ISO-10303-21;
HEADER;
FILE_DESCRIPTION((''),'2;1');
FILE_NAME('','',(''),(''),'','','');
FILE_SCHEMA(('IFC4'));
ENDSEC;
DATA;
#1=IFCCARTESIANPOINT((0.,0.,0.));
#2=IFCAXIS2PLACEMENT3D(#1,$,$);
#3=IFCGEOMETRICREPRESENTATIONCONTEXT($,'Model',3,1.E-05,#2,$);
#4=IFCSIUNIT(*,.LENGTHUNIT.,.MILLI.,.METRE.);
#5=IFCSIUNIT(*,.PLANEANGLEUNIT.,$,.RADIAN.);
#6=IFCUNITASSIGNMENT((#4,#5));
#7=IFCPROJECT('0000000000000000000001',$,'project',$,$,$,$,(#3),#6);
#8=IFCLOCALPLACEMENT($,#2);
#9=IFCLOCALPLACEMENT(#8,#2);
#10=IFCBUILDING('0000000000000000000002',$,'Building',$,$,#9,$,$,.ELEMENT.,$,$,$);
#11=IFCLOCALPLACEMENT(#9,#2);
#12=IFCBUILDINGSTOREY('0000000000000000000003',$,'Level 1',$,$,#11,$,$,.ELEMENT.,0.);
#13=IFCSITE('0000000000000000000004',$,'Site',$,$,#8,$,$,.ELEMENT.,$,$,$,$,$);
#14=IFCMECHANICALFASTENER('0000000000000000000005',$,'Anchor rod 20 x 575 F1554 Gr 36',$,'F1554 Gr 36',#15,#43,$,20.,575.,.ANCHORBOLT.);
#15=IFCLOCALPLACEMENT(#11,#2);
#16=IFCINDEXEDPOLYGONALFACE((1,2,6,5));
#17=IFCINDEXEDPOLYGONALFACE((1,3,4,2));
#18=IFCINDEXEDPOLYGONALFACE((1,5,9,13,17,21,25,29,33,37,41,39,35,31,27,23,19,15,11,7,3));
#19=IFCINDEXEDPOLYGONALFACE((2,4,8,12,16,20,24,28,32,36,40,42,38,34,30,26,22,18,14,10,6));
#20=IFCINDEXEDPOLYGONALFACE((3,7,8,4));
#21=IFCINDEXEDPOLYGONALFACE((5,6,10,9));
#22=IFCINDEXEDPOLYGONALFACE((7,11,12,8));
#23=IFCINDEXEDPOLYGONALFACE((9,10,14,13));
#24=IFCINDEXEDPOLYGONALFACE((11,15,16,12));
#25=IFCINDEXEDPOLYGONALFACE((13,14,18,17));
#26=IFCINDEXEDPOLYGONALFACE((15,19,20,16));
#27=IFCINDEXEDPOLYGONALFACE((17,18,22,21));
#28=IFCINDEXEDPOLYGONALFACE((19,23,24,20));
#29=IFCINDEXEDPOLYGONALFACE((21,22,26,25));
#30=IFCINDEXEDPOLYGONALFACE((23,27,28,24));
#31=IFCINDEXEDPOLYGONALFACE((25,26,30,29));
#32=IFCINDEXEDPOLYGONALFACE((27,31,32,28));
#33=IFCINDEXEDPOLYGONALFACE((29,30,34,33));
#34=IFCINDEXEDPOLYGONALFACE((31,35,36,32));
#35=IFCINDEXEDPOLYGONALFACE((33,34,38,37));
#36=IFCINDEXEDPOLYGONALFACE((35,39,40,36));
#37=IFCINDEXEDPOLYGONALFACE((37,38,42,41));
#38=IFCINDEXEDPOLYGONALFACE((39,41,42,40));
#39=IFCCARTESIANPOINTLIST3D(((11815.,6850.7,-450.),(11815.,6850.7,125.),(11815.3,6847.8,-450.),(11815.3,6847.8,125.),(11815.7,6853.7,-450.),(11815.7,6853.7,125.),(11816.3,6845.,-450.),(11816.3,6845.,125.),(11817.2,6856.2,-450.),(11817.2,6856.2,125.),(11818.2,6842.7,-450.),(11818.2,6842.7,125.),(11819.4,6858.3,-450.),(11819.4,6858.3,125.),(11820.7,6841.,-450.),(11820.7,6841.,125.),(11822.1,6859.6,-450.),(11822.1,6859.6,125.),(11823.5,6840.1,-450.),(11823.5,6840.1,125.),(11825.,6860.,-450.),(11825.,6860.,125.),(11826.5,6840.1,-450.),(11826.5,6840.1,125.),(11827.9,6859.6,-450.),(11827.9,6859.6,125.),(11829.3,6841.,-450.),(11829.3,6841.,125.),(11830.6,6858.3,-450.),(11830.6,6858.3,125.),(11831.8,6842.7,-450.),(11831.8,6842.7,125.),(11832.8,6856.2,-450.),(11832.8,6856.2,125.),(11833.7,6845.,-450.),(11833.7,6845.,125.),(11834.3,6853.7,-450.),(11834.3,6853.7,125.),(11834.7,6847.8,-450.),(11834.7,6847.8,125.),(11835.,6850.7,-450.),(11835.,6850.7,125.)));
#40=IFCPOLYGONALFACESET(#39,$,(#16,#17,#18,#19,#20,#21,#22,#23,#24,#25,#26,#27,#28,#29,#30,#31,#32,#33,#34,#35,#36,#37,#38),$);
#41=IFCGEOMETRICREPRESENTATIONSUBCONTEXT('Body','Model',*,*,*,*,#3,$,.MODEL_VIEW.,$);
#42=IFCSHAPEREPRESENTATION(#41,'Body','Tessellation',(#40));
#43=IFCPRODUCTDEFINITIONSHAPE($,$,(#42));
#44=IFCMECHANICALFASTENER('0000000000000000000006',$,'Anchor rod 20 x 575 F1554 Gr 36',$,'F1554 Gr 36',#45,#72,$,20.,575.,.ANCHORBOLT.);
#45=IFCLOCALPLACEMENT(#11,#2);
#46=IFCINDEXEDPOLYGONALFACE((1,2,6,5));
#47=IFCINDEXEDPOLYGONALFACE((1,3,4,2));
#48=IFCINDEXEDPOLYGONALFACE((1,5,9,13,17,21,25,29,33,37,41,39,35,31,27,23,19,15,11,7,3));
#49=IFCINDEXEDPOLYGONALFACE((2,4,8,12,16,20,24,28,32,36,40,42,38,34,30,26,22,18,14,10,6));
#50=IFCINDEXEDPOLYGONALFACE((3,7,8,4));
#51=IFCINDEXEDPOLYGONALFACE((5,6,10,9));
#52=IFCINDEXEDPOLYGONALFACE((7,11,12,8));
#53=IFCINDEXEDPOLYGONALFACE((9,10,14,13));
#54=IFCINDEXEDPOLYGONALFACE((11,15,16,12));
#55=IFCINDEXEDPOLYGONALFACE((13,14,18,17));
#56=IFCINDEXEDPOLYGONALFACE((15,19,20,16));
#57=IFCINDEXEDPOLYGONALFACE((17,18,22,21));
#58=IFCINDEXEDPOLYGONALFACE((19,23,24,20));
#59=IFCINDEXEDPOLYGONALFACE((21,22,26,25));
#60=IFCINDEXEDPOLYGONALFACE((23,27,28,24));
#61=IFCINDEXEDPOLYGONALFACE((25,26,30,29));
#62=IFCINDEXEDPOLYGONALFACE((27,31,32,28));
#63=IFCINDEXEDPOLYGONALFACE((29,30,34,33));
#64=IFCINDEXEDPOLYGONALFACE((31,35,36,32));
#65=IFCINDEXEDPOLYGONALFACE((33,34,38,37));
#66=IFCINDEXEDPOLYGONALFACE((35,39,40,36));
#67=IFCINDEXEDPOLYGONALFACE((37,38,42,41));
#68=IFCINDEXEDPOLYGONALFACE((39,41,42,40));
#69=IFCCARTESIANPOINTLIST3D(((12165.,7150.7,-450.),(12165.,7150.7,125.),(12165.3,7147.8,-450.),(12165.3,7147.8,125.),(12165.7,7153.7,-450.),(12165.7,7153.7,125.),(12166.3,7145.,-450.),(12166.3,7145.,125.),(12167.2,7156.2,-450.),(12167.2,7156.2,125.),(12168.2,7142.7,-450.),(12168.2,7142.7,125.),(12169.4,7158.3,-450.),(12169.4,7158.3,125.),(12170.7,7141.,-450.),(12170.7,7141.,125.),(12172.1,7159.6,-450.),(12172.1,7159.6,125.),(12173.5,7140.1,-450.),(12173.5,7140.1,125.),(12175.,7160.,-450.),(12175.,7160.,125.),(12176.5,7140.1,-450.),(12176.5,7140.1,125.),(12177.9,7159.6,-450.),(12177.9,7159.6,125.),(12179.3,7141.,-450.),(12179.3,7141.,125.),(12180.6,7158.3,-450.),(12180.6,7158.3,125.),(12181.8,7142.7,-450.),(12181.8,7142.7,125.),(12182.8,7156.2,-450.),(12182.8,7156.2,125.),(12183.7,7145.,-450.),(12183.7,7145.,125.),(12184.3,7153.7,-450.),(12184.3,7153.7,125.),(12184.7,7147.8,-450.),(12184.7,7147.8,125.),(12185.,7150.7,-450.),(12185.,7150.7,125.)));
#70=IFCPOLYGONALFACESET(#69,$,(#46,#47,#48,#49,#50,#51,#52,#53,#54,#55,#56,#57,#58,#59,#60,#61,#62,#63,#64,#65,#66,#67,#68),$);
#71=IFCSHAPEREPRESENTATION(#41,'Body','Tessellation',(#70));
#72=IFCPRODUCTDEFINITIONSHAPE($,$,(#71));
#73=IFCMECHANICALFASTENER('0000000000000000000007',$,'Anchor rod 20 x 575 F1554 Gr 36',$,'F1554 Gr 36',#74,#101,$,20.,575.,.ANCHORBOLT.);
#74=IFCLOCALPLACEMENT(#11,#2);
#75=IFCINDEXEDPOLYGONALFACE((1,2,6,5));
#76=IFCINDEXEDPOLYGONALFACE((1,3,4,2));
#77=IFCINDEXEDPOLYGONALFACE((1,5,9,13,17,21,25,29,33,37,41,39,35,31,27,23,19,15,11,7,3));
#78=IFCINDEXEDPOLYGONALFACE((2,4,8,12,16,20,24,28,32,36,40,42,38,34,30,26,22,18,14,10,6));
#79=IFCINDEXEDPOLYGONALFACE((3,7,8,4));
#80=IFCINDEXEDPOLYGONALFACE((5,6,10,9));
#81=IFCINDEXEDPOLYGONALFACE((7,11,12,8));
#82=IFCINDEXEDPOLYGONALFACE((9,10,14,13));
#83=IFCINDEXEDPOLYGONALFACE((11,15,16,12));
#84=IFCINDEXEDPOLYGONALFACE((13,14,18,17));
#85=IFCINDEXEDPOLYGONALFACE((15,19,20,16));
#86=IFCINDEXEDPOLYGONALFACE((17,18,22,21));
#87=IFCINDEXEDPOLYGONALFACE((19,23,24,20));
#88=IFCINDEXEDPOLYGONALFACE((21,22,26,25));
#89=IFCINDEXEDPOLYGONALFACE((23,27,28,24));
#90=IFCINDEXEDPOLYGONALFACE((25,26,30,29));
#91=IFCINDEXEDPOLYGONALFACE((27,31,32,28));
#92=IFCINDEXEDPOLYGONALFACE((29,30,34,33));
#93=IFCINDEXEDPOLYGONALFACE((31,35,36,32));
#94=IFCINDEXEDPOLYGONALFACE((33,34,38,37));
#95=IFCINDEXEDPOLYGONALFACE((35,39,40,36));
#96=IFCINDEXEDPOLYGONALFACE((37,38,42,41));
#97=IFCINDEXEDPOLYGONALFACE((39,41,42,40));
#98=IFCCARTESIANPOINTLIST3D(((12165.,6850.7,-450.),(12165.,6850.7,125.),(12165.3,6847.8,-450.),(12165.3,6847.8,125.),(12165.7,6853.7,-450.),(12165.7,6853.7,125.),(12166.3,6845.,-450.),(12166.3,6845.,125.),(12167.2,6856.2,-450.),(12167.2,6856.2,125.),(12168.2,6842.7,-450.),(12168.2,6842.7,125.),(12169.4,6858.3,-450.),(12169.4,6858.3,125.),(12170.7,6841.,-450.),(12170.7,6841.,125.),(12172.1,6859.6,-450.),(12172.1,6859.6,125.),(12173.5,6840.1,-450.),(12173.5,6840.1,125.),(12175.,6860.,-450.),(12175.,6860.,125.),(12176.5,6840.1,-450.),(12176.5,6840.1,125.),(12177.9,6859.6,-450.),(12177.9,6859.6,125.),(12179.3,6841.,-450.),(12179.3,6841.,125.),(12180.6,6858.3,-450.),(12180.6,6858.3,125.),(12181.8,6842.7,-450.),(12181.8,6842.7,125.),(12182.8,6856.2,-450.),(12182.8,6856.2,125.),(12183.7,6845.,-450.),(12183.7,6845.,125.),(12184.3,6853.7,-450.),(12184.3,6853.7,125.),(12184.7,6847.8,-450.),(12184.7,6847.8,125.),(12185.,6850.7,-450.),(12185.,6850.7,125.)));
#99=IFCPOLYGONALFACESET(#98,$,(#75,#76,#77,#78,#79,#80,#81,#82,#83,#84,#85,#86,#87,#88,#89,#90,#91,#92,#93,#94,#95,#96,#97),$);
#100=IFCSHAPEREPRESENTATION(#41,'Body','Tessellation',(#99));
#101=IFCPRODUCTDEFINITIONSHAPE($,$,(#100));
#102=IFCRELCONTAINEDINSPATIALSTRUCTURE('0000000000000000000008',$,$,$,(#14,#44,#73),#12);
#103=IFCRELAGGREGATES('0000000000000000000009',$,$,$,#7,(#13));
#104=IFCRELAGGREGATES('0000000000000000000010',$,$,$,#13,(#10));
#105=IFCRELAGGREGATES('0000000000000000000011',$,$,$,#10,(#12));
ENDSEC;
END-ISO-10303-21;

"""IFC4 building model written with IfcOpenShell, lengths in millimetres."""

from ifc_helpers import new_model, si_unit, frame, origin, origin_2d, place, context, subcontext, project, spatial, circle, extrude, element, save


model = new_model("IFC4")

# Units and contexts
model_context = context("Model", 3, precision=1e-05, world=origin())
body_context = subcontext(model_context, "Body", "Model", "MODEL_VIEW")
ifc_project = project(units=[si_unit("LENGTHUNIT", "METRE", prefix="MILLI"), si_unit("PLANEANGLEUNIT", "RADIAN")], contexts=[model_context])

# Site, building, storey
site_placement = place(None, origin())
site = spatial("IfcSite", under=ifc_project, at=site_placement, Name="Site", CompositionType="ELEMENT")
building_placement = place(site_placement, origin())
building = spatial("IfcBuilding", under=site, at=building_placement, Name="Building", CompositionType="ELEMENT")
storey_placement = place(building_placement, origin())
storey = spatial("IfcBuildingStorey", under=building, at=storey_placement, Name="Level 1", CompositionType="ELEMENT", Elevation=0.0)

# Mechanical fasteners
for number, where, z_axis, x_axis, name in (
    (1, (11825.0, 6850.0, 125.0), (0.0, 0.0, -1.0), (0.0, 1.0, 0.0), "Anchor rod 20 x 575 F1554 Gr 36"),
    (2, (12175.0, 7150.0, 125.0), (0.0, 0.0, -1.0), (0.0, 1.0, 0.0), "Anchor rod 20 x 575 F1554 Gr 36"),
    (3, (12175.0, 6850.0, 125.0), (0.0, 0.0, -1.0), (0.0, 1.0, 0.0), "Anchor rod 20 x 575 F1554 Gr 36"),
):
    element("IfcMechanicalFastener", number, at=place(storey_placement, frame(where, z_axis=z_axis, x_axis=x_axis)), inside=storey, Name=name, ObjectType="F1554 Gr 36", NominalDiameter=20.0, NominalLength=575.0, PredefinedType="ANCHORBOLT", context=body_context, shape_type="SweptSolid", body=[
        extrude(circle(Radius=10.0, at=origin_2d()), origin(), (0.0, 0.0, 1.0), 575.0),
    ])

save(model, "model.ifc")
